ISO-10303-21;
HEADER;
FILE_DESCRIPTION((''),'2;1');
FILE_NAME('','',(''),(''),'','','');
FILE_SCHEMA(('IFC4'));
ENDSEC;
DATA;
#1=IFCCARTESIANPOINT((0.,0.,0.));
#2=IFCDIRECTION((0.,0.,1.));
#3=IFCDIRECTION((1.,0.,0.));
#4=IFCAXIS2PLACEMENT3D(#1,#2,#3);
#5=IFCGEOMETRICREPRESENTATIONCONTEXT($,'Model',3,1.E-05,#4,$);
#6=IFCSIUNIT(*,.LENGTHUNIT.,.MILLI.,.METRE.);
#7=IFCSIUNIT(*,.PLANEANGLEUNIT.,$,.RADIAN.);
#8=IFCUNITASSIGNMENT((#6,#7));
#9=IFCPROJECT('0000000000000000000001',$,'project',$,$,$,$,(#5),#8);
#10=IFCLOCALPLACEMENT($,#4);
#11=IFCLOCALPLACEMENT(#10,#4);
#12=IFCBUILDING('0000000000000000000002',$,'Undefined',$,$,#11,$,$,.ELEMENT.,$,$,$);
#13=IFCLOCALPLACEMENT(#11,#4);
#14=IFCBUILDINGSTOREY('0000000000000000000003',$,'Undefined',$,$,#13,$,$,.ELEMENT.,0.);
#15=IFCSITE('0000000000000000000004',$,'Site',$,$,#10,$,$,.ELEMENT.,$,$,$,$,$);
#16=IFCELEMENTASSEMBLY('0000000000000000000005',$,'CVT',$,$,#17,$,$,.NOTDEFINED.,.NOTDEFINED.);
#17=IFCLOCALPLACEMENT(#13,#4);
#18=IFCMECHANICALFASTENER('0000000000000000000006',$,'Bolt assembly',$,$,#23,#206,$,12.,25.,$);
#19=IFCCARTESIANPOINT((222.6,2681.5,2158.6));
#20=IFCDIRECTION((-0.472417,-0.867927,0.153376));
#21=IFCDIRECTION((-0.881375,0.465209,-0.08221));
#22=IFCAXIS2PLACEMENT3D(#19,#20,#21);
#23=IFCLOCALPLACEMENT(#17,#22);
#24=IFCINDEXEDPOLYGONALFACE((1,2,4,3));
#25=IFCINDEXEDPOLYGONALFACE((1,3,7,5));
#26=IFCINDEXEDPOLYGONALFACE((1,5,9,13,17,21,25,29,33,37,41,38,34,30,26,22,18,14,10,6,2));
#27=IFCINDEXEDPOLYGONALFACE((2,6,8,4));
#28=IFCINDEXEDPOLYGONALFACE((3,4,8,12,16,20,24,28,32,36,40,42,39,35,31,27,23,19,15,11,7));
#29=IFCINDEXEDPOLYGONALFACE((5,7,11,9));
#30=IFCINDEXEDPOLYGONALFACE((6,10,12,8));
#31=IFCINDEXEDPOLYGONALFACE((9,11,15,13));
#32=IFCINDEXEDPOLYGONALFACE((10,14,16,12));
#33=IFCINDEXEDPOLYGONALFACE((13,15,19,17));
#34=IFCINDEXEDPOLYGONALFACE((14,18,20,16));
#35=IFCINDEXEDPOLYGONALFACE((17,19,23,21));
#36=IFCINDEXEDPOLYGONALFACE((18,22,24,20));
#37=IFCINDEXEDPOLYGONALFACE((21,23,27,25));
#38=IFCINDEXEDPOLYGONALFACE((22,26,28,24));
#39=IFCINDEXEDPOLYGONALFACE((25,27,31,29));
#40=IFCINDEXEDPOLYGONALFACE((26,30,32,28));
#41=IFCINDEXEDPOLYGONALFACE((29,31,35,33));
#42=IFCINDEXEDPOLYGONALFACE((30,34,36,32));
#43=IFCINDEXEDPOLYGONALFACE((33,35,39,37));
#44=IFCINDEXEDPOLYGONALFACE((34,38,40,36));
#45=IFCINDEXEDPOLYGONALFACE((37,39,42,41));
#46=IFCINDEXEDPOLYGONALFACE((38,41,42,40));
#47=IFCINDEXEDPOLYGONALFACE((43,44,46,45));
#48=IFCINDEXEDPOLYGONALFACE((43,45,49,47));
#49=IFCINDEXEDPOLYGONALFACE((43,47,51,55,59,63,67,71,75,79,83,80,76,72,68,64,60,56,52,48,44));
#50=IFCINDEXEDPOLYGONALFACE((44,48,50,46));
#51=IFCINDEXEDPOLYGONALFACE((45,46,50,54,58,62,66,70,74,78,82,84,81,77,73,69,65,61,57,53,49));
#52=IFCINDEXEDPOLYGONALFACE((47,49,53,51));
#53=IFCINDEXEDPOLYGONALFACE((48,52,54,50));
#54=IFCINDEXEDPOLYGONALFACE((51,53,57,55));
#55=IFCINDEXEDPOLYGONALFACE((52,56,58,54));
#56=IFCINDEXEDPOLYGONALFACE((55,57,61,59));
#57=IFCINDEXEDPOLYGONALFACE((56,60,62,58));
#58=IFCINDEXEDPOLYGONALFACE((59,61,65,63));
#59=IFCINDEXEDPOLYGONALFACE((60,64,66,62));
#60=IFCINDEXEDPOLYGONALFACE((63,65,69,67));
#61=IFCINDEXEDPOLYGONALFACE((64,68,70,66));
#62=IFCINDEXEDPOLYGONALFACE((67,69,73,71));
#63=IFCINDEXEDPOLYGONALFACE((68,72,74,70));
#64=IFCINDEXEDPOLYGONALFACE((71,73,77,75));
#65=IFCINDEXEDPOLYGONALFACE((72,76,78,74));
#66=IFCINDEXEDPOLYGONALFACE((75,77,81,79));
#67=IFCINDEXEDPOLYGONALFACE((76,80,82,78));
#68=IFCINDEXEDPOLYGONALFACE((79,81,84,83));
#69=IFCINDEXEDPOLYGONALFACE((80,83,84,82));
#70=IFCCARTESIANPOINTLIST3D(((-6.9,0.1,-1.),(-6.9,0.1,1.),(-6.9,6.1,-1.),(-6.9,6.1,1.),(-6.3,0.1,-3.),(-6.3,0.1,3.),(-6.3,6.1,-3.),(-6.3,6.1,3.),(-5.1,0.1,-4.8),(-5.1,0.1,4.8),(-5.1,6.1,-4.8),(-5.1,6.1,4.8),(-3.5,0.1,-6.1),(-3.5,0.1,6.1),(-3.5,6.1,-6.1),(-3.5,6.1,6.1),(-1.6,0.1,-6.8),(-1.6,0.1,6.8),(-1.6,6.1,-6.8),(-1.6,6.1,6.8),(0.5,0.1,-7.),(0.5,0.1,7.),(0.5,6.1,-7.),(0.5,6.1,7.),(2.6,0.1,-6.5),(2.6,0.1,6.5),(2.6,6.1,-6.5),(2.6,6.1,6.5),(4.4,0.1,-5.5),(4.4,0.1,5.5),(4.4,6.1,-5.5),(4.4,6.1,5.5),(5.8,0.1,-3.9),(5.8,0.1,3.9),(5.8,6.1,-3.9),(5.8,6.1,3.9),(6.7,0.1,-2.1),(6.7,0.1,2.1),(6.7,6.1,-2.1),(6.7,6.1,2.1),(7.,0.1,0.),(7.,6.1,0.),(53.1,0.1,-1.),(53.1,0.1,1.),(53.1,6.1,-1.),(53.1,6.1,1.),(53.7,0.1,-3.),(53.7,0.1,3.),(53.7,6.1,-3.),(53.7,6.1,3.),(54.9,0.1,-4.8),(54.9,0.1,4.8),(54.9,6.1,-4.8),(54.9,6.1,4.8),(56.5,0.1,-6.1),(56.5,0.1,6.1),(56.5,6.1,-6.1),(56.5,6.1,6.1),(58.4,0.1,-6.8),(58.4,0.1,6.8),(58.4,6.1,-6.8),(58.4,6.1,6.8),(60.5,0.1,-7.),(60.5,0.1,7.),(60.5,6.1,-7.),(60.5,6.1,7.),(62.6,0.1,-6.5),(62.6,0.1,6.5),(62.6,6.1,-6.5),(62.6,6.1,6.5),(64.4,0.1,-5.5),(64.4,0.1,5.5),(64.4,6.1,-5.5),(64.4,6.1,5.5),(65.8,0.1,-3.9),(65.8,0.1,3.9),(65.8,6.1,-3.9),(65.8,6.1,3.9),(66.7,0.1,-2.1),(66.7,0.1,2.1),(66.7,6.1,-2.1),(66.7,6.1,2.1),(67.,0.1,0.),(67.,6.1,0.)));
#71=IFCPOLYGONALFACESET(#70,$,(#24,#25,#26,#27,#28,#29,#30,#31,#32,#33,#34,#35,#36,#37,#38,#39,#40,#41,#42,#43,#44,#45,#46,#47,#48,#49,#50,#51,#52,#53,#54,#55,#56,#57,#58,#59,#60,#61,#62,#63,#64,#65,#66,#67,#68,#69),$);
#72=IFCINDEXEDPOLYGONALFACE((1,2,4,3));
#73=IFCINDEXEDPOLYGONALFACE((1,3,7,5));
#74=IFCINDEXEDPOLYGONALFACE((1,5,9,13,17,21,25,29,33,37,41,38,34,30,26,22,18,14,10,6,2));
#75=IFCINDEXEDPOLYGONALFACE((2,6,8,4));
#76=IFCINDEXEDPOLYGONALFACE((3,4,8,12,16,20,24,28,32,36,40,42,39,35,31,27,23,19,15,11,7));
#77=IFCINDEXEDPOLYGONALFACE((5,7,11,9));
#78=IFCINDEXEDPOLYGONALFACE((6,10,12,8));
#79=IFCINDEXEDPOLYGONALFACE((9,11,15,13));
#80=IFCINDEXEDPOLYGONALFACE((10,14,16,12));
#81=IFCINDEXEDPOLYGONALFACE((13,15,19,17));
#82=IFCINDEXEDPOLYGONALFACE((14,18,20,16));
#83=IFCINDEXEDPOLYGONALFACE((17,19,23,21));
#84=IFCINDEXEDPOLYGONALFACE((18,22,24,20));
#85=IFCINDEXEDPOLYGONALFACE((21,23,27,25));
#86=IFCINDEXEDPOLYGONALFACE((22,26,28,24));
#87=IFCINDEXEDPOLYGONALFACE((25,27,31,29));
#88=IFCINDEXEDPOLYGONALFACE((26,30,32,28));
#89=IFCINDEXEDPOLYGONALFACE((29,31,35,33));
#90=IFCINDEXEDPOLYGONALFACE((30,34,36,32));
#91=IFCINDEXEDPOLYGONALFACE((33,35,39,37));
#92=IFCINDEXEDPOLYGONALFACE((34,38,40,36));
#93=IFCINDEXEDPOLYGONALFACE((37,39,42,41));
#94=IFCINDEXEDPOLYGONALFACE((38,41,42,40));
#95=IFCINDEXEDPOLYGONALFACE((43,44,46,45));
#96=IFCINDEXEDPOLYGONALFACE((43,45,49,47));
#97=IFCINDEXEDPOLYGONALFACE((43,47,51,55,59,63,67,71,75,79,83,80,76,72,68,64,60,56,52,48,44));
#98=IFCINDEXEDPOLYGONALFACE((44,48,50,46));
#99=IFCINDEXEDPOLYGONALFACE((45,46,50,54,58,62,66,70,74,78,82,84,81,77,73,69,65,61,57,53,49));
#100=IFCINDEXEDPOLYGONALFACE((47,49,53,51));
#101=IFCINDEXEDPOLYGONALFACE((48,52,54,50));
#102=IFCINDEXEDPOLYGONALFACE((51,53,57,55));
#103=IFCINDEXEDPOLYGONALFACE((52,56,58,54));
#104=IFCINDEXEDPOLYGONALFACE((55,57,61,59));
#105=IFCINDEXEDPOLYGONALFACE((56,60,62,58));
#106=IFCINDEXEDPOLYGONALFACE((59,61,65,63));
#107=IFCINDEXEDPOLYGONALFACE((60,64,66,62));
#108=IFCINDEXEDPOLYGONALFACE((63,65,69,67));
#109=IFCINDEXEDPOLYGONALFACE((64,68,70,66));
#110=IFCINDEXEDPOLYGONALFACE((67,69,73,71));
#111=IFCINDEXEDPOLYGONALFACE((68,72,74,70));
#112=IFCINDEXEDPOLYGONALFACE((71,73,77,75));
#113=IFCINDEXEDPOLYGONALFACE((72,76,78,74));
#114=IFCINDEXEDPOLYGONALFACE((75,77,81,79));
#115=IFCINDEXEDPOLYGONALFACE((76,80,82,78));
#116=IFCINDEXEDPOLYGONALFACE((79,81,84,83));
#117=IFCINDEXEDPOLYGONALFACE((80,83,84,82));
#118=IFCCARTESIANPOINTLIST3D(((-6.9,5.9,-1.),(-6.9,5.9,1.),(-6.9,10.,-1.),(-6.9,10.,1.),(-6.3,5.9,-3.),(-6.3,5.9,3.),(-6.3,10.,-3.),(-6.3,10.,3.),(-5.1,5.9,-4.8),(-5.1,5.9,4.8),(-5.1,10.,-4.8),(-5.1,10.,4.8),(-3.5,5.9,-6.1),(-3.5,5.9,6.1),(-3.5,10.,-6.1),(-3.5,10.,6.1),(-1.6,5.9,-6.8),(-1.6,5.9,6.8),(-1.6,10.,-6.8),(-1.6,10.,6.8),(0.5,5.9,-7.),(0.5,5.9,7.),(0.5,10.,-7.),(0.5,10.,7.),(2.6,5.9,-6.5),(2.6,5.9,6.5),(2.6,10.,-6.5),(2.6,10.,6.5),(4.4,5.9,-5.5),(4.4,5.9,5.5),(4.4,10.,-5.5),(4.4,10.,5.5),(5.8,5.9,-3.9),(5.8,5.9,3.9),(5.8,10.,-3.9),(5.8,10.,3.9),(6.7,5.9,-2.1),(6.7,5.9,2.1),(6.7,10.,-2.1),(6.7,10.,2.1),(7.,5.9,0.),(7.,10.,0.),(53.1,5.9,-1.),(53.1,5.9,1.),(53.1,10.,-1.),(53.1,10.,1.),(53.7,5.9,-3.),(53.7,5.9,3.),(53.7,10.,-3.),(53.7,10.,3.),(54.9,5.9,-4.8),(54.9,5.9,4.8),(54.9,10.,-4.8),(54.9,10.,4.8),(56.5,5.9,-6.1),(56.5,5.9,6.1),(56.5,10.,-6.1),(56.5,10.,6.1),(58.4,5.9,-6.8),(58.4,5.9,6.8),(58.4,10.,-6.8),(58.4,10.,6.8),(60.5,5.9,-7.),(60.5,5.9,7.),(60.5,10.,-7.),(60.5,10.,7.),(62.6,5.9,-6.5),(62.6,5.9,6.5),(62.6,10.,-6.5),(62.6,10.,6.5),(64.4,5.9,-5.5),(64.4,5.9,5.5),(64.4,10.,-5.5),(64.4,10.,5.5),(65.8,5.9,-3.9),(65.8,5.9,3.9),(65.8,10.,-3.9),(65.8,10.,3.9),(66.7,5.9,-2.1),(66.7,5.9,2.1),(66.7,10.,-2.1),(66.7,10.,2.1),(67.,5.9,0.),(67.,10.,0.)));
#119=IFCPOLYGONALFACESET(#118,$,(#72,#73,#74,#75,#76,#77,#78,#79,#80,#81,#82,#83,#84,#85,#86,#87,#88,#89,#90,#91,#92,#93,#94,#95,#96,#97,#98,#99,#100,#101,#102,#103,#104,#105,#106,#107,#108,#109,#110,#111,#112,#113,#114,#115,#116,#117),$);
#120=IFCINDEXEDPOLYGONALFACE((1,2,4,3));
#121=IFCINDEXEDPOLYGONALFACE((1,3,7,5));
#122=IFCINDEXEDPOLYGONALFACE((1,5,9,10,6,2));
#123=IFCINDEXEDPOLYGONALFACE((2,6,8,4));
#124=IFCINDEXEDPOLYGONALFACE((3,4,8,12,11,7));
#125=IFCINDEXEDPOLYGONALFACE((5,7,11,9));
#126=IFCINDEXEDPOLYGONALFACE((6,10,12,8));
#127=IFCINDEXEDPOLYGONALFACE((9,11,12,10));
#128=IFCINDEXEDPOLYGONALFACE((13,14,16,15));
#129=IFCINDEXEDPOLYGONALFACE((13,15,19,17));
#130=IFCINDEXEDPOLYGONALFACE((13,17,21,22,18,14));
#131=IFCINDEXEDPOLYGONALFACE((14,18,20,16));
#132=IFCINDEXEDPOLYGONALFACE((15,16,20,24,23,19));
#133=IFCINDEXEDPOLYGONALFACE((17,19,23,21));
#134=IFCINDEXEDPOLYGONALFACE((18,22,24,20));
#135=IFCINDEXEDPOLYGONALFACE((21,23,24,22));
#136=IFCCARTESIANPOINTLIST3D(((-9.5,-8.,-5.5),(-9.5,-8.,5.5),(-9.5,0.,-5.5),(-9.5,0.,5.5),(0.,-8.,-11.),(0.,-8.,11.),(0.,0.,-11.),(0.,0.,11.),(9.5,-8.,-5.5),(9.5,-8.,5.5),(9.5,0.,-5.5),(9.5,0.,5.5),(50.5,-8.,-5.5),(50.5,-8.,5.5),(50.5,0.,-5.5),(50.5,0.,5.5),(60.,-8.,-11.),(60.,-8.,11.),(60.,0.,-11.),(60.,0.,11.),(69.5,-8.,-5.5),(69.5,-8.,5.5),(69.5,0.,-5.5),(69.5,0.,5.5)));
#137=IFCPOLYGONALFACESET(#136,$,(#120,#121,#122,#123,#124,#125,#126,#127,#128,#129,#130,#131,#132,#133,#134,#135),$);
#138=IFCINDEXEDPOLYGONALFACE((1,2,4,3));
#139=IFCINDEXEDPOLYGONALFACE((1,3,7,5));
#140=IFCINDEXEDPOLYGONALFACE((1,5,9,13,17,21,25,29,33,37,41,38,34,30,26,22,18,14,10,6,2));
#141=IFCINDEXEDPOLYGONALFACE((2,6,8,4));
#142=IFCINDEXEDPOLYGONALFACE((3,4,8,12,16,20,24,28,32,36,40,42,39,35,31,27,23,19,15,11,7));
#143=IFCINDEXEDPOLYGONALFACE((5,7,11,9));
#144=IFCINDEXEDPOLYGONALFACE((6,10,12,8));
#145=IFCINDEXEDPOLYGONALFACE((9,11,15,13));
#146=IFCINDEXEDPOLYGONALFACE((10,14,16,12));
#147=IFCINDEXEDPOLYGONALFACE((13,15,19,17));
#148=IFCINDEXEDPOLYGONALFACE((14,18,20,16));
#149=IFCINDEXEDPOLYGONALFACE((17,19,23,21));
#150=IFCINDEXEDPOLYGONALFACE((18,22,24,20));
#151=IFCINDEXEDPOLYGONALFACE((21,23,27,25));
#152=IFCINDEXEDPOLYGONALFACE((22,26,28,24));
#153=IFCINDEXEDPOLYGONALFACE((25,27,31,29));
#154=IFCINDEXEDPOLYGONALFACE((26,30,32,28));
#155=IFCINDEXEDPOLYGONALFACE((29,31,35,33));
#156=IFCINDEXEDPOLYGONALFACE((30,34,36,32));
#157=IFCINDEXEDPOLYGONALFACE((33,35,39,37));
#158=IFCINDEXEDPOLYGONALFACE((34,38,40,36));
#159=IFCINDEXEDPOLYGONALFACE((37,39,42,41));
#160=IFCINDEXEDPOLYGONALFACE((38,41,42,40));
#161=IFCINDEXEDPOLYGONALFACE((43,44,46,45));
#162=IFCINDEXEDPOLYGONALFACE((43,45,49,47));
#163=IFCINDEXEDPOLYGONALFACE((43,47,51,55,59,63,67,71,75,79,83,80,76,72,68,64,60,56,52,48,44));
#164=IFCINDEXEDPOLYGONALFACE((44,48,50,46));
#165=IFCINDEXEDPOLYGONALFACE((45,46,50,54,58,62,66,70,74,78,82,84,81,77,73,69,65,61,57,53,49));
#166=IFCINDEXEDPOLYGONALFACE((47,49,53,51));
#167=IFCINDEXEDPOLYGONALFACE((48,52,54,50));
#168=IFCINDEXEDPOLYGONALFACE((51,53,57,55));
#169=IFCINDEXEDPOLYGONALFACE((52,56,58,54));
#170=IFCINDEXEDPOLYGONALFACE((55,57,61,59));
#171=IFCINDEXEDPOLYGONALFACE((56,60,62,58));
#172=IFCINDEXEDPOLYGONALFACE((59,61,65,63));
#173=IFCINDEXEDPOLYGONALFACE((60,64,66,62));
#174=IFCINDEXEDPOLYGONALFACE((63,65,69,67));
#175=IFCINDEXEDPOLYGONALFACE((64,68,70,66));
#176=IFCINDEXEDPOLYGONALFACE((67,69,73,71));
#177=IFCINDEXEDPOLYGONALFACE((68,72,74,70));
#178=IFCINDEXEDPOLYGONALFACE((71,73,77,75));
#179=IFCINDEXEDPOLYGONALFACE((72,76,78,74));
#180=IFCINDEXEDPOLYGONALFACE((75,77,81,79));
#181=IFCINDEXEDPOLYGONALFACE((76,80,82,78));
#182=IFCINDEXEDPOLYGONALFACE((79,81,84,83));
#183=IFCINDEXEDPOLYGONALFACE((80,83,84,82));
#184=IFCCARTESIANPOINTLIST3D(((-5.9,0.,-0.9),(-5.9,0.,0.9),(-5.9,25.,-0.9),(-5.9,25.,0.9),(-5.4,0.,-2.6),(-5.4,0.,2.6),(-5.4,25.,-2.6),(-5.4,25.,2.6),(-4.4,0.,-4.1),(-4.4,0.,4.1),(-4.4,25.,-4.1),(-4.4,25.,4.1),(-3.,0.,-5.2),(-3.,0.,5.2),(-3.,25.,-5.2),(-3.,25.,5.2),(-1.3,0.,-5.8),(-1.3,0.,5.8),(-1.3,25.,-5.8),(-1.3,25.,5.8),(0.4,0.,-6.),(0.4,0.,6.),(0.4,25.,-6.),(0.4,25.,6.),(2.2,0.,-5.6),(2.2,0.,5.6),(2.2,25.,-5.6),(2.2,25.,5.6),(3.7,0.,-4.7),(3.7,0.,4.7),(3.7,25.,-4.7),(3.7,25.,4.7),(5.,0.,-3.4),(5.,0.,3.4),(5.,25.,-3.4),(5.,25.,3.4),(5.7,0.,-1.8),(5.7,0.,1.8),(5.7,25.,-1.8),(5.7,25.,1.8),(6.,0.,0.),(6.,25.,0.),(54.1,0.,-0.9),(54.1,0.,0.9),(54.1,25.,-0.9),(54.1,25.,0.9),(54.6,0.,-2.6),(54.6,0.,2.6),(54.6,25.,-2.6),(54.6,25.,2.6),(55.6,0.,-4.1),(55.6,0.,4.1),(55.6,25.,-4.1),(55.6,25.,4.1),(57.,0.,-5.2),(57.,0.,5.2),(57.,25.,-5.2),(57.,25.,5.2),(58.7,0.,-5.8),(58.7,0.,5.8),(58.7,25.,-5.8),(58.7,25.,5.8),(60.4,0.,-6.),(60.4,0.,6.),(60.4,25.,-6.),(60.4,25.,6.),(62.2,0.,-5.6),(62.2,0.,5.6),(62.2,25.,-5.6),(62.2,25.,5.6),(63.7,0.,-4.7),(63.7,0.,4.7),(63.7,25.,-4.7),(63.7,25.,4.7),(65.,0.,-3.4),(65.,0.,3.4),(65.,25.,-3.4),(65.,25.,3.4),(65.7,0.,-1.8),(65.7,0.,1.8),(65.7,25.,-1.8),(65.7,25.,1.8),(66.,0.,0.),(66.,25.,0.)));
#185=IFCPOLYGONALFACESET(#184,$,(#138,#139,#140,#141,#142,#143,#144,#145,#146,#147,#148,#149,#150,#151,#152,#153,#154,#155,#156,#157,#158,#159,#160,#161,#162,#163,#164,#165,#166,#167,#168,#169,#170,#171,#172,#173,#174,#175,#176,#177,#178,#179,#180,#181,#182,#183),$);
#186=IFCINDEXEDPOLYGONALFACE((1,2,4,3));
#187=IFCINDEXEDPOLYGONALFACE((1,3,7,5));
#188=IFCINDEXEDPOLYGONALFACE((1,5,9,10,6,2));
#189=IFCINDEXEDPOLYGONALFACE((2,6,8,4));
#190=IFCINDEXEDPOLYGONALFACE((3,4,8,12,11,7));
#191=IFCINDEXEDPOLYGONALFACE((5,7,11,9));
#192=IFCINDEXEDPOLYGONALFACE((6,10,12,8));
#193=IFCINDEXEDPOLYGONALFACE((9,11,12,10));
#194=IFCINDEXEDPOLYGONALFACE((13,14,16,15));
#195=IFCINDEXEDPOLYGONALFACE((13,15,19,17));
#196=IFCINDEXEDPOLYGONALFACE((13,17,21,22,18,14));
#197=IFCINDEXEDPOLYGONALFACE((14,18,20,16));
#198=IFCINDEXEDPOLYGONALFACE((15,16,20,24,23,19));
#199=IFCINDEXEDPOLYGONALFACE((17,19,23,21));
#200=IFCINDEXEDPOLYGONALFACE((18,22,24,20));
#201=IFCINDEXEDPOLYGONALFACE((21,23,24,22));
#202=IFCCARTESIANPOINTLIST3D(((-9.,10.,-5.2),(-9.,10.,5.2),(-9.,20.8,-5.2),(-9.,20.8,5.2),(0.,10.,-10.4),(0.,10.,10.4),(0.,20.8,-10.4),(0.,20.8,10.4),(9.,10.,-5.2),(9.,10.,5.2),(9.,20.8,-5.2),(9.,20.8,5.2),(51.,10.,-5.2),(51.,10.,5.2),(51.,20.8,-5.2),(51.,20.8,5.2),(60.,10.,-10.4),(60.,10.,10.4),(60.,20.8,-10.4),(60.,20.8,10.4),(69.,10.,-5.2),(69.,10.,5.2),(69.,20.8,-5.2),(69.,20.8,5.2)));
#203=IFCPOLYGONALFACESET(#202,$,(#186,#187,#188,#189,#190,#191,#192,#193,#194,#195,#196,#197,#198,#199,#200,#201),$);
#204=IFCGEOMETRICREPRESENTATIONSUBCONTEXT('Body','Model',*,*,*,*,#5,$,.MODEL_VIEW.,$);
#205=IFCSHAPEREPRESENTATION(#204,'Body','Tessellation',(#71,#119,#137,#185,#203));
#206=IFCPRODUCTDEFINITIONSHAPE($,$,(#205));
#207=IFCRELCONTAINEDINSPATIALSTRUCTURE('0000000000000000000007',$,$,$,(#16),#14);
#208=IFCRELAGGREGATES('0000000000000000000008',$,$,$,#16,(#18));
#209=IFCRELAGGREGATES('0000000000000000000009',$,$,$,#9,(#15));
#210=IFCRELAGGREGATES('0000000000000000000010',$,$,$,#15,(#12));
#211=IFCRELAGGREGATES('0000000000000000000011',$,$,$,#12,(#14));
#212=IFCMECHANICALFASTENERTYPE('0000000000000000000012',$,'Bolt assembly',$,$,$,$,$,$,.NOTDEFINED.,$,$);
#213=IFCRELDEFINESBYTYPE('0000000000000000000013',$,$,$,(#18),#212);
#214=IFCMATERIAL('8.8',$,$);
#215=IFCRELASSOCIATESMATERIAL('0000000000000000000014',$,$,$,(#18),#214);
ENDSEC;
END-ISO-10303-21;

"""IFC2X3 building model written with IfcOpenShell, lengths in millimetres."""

from ifc_helpers import new_model, si_unit, frame, origin_with_axes, origin_2d_with_axis, place, context, subcontext, project, spatial, polyline, circle, outline, extrude, source, transform, mapped, material, type_object, element, aggregate, save


model = new_model("IFC2X3")

# Units and contexts
model_context = context("Model", 3, precision=1e-05, world=origin_with_axes())
body_context = subcontext(model_context, "Body", "Model", "MODEL_VIEW")
ifc_project = project(units=[si_unit("LENGTHUNIT", "METRE", prefix="MILLI"), si_unit("PLANEANGLEUNIT", "RADIAN")], contexts=[model_context])

# Site, building, storey
site_placement = place(None, origin_with_axes())
site = spatial("IfcSite", under=ifc_project, at=site_placement, Name="Site", CompositionType="ELEMENT")
building_placement = place(site_placement, origin_with_axes())
building = spatial("IfcBuilding", under=site, at=building_placement, Name="Undefined", CompositionType="ELEMENT")
storey_placement = place(building_placement, origin_with_axes())
storey = spatial("IfcBuildingStorey", under=building, at=storey_placement, Name="Undefined", CompositionType="ELEMENT", Elevation=0.0)

# Element assembly
assembly_1_placement = place(storey_placement, origin_with_axes())
assembly_1 = element("IfcElementAssembly", 1, at=assembly_1_placement, inside=storey, Name="CVT", AssemblyPlace="NOTDEFINED", PredefinedType="NOTDEFINED")

# Shared definitions
ifc_material_1 = material(Name="8.8")
mechanical_fastener_type = type_object("IfcMechanicalFastenerType", Name="Bolt assembly")

# Mechanical fastener
shared_shape_1 = source(origin_with_axes(), body_context, "Body", "SweptSolid", [
    extrude(circle(Radius=7.0, at=origin_2d_with_axis()), frame((0.0, 0.1, 0.0), z_axis=(0.0, 1.0, 0.0), x_axis=(1.0, 0.0, 0.0)), (0.0, 0.0, 1.0), 6.0),
    extrude(circle(Radius=7.0, at=origin_2d_with_axis()), frame((0.0, 5.9, 0.0), z_axis=(0.0, 1.0, 0.0), x_axis=(1.0, 0.0, 0.0)), (0.0, 0.0, 1.0), 4.1),
    extrude(outline(polyline([(9.5, -5.5), (9.5, 5.5), (0.0, 11.0), (-9.5, 5.5), (-9.5, -5.5), (0.0, -11.0), (9.5, -5.5)])), frame((0.0, -8.0, 0.0), z_axis=(0.0, 1.0, 0.0), x_axis=(1.0, 0.0, 0.0)), (0.0, 0.0, 1.0), 8.0),
    extrude(circle(Radius=6.0, at=origin_2d_with_axis()), frame((0.0, 0.0, 0.0), z_axis=(0.0, 1.0, 0.0), x_axis=(1.0, 0.0, 0.0)), (0.0, 0.0, 1.0), 25.0),
    extrude(outline(polyline([(9.0, -5.2), (9.0, 5.2), (0.0, 10.4), (-9.0, 5.2), (-9.0, -5.2), (0.0, -10.4), (9.0, -5.2)])), frame((0.0, 10.0, 0.0), z_axis=(0.0, 1.0, 0.0), x_axis=(1.0, 0.0, 0.0)), (0.0, 0.0, 1.0), 10.8),
])
mechanical_fastener_1_placement = place(assembly_1_placement, frame((222.6, 2681.5, 2158.6), z_axis=(-0.472417, -0.867927, 0.153376), x_axis=(-0.881375, 0.465209, -0.08221)))
mechanical_fastener_1 = element("IfcMechanicalFastener", 2, at=mechanical_fastener_1_placement, type_object=mechanical_fastener_type, material=ifc_material_1, Name="Bolt assembly", NominalDiameter=12.0, NominalLength=25.0, context=body_context, shape_type="MappedRepresentation", body=[
    mapped(shared_shape_1, transform((0.0, 0.0, 0.0))),
    mapped(shared_shape_1, transform((60.0, 0.0, 0.0))),
])
aggregate(assembly_1, [mechanical_fastener_1])

save(model, "model.ifc")
